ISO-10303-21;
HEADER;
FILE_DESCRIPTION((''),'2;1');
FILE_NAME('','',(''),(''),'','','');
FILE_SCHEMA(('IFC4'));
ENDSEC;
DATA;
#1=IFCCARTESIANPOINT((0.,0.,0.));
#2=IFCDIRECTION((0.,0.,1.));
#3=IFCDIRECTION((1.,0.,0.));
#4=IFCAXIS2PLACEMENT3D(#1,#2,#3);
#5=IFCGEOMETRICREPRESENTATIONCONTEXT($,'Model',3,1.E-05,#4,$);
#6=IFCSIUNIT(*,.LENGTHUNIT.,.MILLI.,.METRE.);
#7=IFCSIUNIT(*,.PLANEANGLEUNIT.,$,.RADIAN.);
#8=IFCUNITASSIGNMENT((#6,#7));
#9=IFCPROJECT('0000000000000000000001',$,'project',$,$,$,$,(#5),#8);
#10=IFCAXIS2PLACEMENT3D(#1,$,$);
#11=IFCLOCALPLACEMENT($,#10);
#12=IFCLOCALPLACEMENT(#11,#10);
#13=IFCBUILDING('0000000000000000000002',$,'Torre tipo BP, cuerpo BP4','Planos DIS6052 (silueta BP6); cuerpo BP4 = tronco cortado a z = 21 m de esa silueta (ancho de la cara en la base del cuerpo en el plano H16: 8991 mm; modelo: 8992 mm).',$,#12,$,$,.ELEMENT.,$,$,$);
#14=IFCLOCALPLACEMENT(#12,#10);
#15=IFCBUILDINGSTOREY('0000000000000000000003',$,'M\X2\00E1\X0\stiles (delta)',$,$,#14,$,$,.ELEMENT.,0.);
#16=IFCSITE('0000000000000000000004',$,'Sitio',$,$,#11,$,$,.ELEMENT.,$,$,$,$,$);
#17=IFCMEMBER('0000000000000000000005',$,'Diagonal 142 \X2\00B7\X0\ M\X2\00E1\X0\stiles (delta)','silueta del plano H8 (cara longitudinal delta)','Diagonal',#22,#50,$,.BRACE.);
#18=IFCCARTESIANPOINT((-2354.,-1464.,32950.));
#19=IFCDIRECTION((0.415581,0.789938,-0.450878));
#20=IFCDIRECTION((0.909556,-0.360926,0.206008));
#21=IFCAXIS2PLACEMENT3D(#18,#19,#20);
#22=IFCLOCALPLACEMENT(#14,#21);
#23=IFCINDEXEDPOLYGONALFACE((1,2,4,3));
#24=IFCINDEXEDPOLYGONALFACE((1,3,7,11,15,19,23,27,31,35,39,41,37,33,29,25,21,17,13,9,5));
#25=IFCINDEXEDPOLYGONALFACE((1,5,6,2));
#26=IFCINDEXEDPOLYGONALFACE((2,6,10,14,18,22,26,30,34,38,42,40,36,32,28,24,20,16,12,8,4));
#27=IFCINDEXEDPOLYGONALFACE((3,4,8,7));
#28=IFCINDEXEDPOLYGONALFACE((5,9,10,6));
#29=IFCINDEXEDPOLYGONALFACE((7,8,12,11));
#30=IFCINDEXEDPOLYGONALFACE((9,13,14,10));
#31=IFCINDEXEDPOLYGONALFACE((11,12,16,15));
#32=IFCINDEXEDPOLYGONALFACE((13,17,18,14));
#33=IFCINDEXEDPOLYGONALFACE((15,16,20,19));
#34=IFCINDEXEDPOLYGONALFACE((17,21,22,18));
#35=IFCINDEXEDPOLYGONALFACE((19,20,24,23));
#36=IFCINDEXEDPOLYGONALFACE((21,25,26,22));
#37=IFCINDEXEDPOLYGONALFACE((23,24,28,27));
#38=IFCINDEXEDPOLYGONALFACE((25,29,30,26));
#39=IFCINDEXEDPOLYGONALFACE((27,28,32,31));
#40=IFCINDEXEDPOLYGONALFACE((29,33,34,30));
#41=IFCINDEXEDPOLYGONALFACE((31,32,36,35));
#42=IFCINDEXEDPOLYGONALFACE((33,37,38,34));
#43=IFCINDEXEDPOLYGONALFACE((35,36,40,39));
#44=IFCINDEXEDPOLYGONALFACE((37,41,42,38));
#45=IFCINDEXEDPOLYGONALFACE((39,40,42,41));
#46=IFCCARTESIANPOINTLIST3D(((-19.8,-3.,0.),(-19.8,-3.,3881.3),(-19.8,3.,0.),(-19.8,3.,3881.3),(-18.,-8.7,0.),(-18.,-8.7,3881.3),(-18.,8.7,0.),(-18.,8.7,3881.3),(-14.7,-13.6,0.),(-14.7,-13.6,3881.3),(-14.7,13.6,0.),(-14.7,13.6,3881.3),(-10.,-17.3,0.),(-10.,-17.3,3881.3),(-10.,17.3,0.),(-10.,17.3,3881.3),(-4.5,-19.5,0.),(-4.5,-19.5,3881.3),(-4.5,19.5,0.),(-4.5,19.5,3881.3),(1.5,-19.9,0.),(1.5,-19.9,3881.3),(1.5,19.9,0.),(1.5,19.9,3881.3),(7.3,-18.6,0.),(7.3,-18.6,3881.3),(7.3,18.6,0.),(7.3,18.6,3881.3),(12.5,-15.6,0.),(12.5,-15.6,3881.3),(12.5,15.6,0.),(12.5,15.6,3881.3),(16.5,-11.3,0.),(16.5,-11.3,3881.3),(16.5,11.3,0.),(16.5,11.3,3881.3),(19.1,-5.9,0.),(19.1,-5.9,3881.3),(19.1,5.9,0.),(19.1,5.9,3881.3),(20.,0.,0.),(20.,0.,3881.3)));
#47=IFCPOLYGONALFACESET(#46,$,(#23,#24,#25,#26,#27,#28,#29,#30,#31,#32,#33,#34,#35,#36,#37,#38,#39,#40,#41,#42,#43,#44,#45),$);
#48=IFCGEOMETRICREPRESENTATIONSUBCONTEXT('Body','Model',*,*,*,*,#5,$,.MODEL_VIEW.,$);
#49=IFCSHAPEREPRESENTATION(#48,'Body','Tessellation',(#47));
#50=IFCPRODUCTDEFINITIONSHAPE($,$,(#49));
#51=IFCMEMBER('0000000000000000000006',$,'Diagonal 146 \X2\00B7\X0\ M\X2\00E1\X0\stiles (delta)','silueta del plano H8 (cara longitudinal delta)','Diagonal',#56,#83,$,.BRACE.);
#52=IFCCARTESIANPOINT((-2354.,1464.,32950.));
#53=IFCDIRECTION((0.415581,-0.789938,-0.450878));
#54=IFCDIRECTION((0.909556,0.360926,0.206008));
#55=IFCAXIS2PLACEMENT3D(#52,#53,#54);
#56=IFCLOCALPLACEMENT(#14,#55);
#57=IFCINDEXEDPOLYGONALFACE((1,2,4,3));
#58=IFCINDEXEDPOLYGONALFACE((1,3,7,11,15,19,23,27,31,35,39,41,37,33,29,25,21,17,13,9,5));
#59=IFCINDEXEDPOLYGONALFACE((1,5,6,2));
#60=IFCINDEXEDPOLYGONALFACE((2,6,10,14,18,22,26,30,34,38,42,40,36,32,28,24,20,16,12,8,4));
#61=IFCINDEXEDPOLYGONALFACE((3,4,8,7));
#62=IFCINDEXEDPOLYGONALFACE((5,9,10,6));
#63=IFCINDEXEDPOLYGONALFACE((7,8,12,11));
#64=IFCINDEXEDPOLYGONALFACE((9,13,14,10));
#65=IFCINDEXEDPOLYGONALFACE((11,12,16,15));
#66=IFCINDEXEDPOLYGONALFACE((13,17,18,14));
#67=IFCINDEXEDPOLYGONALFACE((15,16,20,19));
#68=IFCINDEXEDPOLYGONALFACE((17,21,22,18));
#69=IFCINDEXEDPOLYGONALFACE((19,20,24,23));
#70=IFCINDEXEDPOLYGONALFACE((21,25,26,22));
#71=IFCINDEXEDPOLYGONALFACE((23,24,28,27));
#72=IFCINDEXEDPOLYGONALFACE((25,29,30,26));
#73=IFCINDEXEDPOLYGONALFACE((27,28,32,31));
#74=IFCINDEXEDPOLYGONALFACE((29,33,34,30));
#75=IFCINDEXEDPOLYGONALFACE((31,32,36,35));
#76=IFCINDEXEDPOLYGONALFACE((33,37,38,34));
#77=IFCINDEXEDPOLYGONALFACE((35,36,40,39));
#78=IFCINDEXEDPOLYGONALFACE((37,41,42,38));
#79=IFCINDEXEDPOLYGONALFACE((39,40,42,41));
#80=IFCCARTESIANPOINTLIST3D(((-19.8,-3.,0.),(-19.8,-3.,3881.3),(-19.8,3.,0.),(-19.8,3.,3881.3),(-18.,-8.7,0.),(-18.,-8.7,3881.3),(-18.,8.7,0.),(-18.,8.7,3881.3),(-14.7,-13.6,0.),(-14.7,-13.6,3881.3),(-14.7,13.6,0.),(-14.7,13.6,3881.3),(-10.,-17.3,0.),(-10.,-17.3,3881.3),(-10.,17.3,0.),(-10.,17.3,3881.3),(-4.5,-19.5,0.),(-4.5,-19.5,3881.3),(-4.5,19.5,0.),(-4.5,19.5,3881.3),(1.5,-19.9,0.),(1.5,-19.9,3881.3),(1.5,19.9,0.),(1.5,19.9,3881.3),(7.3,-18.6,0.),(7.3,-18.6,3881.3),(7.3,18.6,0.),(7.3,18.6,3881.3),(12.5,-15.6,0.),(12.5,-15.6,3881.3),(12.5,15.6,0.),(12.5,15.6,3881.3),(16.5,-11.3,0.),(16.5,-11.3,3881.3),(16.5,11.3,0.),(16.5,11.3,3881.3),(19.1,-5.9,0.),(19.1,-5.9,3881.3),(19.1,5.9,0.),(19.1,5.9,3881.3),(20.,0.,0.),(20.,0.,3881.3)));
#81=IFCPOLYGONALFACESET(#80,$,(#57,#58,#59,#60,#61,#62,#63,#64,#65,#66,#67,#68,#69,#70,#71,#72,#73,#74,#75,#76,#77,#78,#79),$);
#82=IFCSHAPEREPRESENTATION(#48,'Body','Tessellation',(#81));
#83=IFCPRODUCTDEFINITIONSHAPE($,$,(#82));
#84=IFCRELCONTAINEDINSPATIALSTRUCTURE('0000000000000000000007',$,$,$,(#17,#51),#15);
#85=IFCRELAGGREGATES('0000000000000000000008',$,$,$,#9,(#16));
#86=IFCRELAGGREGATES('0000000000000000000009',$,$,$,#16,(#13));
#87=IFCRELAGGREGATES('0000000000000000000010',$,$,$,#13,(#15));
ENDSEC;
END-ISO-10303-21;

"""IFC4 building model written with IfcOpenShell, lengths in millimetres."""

from ifc_helpers import new_model, si_unit, frame, origin, origin_with_axes, place, context, subcontext, project, spatial, circle, extrude, element, save


model = new_model("IFC4")

# Units and contexts
model_context = context("Model", 3, precision=1e-05, world=origin_with_axes())
body_context = subcontext(model_context, "Body", "Model", "MODEL_VIEW")
ifc_project = project(units=[si_unit("LENGTHUNIT", "METRE", prefix="MILLI"), si_unit("PLANEANGLEUNIT", "RADIAN")], contexts=[model_context])

# Site, building, storey
site_placement = place(None, origin())
site = spatial("IfcSite", under=ifc_project, at=site_placement, Name="Sitio", CompositionType="ELEMENT")
building_placement = place(site_placement, origin())
building = spatial("IfcBuilding", under=site, at=building_placement, Name="Torre tipo BP, cuerpo BP4", Description="Planos DIS6052 (silueta BP6); cuerpo BP4 = tronco cortado a z = 21 m de esa silueta (ancho de la cara en la base del cuerpo en el plano H16: 8991 mm; modelo: 8992 mm).", CompositionType="ELEMENT")
storey_placement = place(building_placement, origin())
storey = spatial("IfcBuildingStorey", under=building, at=storey_placement, Name="Mástiles (delta)", CompositionType="ELEMENT", Elevation=0.0)

# Members
for number, where, z_axis, x_axis, name in (
    (1, (-2354.0, -1464.0, 32950.0), (0.415581, 0.789938, -0.450878), (0.909556, -0.360926, 0.206008), "Diagonal 142 · Mástiles (delta)"),
    (2, (-2354.0, 1464.0, 32950.0), (0.415581, -0.789938, -0.450878), (0.909556, 0.360926, 0.206008), "Diagonal 146 · Mástiles (delta)"),
):
    element("IfcMember", number, at=place(storey_placement, frame(where, z_axis=z_axis, x_axis=x_axis)), inside=storey, Name=name, Description="silueta del plano H8 (cara longitudinal delta)", ObjectType="Diagonal", PredefinedType="BRACE", context=body_context, shape_type="SweptSolid", body=[
        extrude(circle(Radius=20.0), None, (0.0, 0.0, 1.0), 3881.3),
    ])

save(model, "model.ifc")
